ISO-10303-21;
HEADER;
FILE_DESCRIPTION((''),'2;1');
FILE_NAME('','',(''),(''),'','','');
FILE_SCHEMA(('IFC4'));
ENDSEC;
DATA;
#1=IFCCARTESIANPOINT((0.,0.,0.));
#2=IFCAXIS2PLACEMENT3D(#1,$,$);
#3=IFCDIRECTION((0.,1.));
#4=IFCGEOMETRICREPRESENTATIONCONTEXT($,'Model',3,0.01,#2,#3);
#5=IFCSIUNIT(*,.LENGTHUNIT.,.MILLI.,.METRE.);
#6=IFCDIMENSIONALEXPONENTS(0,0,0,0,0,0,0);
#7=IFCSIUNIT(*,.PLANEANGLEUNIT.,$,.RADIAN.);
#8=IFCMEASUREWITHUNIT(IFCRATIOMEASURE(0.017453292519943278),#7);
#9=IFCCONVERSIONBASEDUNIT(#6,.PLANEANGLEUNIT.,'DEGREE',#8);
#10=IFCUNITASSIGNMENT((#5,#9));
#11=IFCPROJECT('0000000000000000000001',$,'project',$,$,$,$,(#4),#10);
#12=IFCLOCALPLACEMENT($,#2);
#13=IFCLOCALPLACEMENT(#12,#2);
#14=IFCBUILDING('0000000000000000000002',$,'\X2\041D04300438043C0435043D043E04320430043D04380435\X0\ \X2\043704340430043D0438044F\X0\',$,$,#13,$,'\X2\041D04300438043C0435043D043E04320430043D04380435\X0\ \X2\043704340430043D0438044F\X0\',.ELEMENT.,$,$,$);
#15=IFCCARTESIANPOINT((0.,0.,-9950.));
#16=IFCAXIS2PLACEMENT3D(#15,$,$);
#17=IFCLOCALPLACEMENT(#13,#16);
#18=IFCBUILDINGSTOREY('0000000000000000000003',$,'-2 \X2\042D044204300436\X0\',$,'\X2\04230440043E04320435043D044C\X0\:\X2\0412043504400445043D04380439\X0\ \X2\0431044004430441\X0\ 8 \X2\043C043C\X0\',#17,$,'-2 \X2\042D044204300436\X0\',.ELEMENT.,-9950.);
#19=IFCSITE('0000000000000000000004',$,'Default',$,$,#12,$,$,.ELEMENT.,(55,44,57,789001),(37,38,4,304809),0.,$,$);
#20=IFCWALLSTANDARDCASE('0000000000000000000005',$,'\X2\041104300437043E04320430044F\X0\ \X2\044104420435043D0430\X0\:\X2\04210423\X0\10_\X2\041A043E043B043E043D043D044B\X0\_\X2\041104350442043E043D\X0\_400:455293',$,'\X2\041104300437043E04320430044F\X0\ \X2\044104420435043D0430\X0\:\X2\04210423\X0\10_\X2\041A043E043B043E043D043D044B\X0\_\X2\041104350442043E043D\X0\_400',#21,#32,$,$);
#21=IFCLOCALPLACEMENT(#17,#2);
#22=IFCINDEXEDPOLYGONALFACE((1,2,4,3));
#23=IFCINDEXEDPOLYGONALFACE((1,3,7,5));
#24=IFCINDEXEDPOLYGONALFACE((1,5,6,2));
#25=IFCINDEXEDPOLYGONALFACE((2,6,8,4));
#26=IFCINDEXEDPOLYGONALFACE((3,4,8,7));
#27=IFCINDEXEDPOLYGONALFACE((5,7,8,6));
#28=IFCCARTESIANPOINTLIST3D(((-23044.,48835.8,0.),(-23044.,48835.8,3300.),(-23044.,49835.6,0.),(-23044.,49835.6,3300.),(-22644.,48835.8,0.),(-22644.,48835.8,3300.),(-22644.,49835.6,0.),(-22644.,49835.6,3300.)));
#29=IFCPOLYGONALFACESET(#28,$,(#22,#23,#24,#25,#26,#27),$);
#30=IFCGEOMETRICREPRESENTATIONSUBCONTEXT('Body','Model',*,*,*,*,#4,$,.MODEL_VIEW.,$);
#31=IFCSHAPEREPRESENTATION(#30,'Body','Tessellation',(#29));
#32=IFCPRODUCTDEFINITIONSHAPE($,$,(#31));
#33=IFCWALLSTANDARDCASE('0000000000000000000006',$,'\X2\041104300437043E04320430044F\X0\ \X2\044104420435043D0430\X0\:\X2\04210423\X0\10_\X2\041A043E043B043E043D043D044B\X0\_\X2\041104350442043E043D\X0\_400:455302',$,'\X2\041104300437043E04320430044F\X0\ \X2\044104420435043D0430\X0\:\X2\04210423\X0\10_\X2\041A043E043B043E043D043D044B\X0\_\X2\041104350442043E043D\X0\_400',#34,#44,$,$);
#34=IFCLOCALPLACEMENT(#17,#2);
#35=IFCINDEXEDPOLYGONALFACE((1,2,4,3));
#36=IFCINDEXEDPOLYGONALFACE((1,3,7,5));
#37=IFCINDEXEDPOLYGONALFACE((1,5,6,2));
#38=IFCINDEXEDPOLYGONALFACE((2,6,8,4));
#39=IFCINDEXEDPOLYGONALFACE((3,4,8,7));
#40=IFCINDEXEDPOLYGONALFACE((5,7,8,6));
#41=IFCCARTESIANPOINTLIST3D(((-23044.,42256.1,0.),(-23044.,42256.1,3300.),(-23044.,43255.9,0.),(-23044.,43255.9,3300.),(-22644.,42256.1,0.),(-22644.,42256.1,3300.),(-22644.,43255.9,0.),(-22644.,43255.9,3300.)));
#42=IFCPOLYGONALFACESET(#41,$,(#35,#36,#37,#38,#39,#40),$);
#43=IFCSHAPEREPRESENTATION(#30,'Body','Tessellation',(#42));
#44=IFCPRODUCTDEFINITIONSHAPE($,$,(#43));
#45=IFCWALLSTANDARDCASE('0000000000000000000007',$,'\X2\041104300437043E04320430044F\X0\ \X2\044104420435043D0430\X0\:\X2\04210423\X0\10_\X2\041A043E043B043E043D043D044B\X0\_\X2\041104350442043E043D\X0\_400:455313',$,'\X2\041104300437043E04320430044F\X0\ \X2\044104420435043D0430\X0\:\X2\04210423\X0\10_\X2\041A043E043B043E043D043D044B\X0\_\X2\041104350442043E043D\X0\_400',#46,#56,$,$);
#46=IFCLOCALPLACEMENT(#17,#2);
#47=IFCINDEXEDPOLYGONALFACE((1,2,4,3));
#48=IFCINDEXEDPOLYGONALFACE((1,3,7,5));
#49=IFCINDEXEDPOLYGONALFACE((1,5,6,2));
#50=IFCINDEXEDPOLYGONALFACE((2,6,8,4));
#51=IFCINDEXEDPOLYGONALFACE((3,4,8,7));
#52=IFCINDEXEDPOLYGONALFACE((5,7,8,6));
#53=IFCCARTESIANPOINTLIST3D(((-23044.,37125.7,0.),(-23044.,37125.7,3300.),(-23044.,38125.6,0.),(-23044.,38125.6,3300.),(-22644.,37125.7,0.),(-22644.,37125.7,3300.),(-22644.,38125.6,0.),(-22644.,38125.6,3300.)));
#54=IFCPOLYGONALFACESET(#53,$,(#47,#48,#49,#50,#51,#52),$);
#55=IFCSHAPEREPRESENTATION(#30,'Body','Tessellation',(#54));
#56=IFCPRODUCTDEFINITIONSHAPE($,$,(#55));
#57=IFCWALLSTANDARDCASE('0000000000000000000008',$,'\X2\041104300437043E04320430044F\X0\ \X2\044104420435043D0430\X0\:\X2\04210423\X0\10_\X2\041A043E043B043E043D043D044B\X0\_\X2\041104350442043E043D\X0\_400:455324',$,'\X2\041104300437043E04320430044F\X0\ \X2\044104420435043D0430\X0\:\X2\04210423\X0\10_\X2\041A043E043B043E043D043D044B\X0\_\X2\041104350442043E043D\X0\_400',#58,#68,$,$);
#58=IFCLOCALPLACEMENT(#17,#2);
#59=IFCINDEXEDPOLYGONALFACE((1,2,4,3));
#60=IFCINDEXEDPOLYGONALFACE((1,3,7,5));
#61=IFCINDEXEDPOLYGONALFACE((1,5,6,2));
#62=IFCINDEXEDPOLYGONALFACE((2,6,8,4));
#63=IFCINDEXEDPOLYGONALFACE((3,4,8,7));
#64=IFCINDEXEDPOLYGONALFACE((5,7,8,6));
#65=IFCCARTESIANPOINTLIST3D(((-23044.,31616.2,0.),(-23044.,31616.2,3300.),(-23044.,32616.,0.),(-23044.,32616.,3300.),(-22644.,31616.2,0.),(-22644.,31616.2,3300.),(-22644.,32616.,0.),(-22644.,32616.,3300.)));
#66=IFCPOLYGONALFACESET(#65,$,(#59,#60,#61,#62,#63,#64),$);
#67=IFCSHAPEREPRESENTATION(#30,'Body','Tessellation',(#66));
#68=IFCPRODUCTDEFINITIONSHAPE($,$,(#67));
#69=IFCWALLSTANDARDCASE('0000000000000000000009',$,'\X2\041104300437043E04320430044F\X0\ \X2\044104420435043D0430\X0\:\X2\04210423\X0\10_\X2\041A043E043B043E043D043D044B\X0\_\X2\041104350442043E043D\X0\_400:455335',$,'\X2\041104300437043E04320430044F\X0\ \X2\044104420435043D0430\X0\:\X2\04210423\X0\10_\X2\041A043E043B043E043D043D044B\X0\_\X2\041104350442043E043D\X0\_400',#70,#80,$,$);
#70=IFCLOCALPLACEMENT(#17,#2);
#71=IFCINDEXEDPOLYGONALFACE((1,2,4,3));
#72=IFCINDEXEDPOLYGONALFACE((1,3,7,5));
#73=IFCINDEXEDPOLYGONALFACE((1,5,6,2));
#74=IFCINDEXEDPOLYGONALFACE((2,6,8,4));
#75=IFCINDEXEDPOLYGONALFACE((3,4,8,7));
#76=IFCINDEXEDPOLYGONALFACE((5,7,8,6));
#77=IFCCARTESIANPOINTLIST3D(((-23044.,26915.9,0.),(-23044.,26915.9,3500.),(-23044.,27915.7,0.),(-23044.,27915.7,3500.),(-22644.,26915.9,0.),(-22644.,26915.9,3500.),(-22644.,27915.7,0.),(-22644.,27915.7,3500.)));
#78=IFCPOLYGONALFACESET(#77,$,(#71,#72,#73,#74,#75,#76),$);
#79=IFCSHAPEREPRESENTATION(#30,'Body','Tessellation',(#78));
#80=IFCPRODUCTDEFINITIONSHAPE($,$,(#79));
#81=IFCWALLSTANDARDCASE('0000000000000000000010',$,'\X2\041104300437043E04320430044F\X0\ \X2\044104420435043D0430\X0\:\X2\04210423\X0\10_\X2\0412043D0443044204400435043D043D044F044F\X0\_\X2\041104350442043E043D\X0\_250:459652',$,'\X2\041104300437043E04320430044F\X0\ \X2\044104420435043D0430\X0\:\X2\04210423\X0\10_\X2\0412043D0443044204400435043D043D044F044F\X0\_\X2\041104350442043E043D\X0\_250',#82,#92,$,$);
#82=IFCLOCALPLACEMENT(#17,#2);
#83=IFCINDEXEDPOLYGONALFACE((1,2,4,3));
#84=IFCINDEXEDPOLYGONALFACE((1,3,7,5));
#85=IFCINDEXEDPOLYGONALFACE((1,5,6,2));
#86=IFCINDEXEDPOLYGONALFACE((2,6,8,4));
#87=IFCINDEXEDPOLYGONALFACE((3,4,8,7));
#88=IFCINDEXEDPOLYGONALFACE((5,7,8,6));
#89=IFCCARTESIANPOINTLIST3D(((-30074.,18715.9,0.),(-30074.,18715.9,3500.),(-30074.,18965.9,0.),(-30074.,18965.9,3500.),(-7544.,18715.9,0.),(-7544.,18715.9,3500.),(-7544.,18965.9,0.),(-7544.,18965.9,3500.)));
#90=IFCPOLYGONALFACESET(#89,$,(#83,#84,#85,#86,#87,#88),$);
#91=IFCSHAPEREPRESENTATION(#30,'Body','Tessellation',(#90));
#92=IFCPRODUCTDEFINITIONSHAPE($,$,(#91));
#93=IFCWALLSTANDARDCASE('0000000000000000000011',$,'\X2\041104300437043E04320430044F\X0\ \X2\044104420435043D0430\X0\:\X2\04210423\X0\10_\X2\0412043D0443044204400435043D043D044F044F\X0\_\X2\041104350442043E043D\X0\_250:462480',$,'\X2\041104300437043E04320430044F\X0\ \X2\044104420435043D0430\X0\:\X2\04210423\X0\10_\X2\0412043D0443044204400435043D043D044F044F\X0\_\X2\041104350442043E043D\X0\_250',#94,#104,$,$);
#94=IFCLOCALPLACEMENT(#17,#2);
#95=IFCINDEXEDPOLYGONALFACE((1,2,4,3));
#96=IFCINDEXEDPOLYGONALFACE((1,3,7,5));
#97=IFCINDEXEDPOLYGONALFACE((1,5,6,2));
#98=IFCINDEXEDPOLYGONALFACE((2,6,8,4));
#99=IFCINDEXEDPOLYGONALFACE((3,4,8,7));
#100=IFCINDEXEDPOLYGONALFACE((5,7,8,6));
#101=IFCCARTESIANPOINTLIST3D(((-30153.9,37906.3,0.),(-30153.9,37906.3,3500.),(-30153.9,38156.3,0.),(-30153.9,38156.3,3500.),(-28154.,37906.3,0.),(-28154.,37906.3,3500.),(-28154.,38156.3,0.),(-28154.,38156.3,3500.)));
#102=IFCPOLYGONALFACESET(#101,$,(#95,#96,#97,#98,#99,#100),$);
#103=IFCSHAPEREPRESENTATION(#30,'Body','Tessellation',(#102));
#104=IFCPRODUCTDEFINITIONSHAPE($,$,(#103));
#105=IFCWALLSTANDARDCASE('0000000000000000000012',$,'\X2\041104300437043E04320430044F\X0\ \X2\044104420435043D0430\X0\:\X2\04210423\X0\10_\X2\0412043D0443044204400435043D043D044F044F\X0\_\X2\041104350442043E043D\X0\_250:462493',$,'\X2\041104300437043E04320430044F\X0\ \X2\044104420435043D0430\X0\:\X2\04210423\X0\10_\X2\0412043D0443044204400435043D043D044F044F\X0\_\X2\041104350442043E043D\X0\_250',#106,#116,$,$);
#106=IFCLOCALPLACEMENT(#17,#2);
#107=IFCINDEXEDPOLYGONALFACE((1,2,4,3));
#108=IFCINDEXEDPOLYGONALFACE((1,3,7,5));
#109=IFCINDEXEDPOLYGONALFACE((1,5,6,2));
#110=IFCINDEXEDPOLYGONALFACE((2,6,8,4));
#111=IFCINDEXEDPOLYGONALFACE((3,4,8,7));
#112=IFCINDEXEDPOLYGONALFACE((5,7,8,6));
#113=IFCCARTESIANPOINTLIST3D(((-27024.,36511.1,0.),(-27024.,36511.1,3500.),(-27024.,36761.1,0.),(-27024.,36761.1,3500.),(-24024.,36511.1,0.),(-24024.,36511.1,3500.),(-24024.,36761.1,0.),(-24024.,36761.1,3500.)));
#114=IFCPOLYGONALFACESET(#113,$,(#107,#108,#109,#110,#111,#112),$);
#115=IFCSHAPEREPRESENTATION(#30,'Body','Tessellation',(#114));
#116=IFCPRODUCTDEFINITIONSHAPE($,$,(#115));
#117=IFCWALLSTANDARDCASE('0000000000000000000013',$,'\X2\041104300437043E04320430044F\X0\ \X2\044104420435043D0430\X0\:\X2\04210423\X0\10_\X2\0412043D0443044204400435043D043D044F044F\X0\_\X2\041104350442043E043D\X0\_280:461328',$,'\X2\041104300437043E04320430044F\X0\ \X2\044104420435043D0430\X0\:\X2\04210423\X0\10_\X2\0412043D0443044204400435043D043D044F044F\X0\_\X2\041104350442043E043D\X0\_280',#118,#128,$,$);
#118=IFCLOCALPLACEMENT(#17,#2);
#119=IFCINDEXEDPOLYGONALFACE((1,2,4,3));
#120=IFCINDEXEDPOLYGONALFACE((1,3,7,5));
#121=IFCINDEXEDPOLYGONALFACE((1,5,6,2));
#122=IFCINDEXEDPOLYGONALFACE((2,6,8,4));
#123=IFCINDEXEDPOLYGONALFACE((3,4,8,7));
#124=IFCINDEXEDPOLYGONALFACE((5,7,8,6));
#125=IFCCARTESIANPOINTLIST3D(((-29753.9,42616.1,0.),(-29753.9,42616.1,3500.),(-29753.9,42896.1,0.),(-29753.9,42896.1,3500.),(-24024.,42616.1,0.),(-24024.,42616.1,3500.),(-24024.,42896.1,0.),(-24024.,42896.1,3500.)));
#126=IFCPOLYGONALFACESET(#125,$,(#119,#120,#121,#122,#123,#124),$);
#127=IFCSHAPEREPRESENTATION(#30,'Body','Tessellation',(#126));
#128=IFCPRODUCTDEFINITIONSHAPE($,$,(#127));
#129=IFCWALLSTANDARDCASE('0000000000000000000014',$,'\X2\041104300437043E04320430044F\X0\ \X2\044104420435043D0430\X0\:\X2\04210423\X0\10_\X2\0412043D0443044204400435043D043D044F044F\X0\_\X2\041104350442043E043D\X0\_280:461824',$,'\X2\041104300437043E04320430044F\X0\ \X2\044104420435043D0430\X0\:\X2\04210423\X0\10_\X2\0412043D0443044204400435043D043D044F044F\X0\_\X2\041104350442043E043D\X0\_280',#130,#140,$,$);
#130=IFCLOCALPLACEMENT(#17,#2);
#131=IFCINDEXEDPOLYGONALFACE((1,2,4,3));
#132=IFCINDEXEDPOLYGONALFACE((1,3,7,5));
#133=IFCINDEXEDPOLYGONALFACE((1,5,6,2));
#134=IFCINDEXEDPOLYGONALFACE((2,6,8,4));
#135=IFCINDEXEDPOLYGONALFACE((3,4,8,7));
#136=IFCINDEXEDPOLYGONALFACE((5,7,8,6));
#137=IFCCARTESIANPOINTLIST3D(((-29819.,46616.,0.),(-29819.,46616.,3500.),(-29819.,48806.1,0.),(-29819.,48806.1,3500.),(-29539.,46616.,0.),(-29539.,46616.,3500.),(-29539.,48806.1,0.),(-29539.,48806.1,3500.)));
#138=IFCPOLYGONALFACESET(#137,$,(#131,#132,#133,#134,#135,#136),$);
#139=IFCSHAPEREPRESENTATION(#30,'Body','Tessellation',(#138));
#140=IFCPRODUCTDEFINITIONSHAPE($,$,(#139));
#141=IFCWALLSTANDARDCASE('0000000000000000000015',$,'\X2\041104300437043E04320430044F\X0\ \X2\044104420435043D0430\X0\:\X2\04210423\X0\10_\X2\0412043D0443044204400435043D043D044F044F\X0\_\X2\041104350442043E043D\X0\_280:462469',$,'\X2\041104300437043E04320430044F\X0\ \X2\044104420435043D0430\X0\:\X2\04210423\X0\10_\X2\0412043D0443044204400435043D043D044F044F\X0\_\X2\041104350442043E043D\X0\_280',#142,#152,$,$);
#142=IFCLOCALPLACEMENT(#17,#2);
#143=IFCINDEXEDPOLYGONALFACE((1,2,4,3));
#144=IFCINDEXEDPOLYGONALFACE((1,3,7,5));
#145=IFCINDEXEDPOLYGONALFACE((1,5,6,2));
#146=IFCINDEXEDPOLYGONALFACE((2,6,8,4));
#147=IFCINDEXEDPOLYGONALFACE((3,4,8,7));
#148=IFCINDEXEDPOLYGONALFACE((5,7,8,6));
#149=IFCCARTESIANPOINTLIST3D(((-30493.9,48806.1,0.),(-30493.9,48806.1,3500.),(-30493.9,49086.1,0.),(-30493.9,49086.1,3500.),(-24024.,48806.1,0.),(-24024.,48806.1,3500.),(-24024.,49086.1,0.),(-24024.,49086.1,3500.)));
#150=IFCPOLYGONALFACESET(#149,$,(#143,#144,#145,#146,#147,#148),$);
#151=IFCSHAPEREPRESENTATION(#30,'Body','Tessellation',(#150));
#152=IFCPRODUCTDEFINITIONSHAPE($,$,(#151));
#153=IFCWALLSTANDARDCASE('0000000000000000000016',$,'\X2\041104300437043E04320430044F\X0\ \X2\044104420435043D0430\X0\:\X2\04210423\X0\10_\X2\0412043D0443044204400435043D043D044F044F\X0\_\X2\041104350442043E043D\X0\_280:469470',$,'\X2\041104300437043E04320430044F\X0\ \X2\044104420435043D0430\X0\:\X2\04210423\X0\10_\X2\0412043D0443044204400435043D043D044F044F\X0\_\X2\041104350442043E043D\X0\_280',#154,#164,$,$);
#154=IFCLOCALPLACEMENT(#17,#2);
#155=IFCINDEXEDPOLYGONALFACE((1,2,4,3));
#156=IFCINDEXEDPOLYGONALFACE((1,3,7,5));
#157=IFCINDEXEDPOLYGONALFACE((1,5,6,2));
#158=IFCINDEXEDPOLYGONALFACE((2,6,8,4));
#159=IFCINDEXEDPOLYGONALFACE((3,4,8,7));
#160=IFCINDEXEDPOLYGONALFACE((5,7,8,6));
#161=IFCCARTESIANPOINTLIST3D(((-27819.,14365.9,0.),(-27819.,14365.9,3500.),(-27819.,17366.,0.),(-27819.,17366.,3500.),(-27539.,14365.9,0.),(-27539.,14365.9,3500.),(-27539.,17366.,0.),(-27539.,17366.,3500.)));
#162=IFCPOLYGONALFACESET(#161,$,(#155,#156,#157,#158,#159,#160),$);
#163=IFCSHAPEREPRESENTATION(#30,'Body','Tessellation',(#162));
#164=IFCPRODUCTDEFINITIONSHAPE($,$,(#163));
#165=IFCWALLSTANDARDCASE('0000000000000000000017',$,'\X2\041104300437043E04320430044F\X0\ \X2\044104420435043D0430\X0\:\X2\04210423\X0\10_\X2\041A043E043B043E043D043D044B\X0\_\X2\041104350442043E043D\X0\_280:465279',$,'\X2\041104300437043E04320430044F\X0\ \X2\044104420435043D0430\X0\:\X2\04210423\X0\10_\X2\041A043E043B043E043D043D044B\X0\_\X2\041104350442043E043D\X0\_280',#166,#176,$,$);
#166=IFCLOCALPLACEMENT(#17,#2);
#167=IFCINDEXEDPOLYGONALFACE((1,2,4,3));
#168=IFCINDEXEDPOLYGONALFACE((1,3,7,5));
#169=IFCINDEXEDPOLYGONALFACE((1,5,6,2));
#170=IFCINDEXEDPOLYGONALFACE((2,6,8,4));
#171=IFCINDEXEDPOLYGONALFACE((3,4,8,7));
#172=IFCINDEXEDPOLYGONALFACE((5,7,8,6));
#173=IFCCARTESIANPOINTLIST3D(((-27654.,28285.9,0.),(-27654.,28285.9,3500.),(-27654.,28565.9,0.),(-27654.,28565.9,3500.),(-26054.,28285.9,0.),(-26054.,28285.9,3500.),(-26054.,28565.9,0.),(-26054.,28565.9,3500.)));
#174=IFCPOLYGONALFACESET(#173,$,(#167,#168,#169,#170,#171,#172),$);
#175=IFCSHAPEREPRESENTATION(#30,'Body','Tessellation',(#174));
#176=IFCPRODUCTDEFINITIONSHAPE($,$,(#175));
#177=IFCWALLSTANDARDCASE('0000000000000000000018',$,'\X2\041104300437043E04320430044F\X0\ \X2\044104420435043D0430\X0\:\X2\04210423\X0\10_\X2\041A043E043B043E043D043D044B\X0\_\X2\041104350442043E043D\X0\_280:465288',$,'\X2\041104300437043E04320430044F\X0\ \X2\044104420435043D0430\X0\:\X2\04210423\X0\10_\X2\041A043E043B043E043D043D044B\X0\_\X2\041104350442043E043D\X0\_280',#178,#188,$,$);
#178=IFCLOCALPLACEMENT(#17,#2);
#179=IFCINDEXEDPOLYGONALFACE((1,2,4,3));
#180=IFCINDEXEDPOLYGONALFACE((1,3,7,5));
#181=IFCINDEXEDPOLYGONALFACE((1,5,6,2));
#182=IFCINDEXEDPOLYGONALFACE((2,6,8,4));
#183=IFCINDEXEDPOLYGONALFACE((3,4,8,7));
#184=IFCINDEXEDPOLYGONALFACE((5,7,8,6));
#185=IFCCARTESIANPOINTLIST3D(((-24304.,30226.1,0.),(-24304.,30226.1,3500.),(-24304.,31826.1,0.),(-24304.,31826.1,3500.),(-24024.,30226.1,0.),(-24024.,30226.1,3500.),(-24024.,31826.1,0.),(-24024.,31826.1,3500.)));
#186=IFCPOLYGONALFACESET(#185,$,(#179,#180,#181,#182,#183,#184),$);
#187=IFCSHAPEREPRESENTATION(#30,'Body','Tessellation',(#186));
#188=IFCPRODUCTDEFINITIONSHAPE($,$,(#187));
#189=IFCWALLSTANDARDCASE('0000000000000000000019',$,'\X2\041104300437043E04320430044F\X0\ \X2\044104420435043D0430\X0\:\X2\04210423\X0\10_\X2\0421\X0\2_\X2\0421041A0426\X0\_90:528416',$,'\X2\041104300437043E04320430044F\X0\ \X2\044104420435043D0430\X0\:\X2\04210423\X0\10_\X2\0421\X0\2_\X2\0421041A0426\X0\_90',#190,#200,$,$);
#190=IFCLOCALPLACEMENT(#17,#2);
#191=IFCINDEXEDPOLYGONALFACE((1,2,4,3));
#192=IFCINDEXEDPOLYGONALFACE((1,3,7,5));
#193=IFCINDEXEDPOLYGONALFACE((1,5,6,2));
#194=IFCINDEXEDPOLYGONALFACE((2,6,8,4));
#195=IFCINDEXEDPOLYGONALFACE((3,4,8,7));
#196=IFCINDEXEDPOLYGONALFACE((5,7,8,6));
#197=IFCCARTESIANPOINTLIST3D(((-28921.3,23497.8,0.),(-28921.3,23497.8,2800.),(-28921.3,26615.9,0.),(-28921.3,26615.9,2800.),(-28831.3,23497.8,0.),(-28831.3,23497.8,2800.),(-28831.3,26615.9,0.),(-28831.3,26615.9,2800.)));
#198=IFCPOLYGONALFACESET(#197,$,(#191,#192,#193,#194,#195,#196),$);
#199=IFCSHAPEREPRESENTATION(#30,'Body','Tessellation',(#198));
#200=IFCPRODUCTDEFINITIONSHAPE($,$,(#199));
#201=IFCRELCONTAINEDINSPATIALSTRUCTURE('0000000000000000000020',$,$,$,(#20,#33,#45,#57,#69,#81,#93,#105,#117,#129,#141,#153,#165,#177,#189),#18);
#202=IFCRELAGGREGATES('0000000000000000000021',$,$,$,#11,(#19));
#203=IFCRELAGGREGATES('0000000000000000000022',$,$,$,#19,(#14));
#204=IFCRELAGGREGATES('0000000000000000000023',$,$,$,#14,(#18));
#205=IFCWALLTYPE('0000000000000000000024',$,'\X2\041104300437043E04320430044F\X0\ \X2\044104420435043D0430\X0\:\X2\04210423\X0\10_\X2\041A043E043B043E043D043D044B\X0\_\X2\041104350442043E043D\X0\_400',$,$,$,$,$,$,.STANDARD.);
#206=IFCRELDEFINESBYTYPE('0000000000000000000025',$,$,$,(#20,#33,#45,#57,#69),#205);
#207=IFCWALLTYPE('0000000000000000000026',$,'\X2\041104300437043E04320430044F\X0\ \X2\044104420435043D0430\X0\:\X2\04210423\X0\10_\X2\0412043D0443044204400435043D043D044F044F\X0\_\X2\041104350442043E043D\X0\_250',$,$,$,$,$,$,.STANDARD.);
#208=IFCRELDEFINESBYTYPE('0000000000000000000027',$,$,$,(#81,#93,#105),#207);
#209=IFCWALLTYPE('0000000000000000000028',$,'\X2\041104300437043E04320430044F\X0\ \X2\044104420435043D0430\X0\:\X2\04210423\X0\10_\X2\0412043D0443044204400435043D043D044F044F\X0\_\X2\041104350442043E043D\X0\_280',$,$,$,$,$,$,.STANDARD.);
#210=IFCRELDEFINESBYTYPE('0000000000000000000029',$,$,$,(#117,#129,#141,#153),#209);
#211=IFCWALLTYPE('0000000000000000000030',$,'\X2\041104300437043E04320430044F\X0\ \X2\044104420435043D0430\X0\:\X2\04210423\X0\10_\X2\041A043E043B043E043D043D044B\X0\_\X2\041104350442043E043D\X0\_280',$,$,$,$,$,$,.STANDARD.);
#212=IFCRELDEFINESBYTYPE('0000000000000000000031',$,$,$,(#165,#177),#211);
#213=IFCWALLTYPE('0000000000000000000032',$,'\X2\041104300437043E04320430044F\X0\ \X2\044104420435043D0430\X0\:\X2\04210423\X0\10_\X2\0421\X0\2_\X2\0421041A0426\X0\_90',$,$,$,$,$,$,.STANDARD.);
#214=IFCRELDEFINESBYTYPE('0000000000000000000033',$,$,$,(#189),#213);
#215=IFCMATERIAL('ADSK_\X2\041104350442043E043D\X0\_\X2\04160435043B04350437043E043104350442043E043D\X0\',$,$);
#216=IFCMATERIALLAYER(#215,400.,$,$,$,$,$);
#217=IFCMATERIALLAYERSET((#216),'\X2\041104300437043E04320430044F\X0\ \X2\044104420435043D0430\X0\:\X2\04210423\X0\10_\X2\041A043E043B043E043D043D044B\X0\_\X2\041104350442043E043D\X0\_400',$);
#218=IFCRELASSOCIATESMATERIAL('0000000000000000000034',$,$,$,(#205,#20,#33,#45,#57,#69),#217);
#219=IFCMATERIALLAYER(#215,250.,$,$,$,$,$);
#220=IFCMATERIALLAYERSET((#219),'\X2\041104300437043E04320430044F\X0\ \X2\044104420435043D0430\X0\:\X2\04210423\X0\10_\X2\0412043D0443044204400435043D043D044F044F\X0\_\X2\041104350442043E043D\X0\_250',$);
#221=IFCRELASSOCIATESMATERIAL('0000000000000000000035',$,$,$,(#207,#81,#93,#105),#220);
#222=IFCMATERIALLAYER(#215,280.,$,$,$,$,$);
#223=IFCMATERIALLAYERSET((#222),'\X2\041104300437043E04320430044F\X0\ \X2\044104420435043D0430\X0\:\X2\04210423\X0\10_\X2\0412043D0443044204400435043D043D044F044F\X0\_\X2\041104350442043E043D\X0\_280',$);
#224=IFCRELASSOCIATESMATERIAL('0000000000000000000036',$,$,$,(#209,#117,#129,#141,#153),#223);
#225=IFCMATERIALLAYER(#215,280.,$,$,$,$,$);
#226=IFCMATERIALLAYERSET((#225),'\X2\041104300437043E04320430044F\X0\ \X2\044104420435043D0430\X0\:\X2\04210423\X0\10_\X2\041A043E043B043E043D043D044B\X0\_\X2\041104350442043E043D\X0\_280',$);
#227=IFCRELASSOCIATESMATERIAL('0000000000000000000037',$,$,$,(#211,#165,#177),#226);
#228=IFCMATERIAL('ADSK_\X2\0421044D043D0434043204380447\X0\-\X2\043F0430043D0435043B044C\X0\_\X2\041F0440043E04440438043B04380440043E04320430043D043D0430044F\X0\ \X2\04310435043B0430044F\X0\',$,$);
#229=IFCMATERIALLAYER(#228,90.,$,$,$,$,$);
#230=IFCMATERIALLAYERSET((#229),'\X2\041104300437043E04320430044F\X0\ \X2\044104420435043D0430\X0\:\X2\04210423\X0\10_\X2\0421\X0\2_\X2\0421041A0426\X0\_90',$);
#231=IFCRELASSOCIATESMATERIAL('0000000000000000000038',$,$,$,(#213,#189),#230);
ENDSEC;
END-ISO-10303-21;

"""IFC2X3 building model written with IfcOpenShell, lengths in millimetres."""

from ifc_helpers import new_model, entity, si_unit, converted_unit, direction, frame, frame_2d, origin, place, context, subcontext, project, spatial, rectangle, extrude, material, layer, layer_set, layer_usage, type_object, element, save


model = new_model("IFC2X3")

# Units and contexts
model_context = context("Model", 3, precision=0.01, world=origin(), true_north=direction((0.0, 1.0)))
body_context = subcontext(model_context, "Body", "Model", "MODEL_VIEW")
ifc_project = project(units=[si_unit("LENGTHUNIT", "METRE", prefix="MILLI"), converted_unit("PLANEANGLEUNIT", "DEGREE", entity("IfcRatioMeasure", 0.017453292519943278), si_unit("PLANEANGLEUNIT", "RADIAN"), dimensions=[0, 0, 0, 0, 0, 0, 0])], contexts=[model_context])

# Site, building, storey
site_placement = place(None, origin())
site = spatial("IfcSite", under=ifc_project, at=site_placement, Name="Default", CompositionType="ELEMENT", RefLatitude=(55, 44, 57, 789001), RefLongitude=(37, 38, 4, 304809), RefElevation=0.0)
building_placement = place(site_placement, origin())
building = spatial("IfcBuilding", under=site, at=building_placement, Name="Наименование здания", LongName="Наименование здания", CompositionType="ELEMENT")
storey_placement = place(building_placement, frame((0.0, 0.0, -9950.0)))
storey = spatial("IfcBuildingStorey", under=building, at=storey_placement, Name="-2 Этаж", ObjectType="Уровень:Верхний брус 8 мм", LongName="-2 Этаж", CompositionType="ELEMENT", Elevation=-9950.0)

# Walls
ifc_material_1 = material(Name="ADSK_Бетон_Железобетон")
ifc_layer_1 = layer(ifc_material_1, 400.0)
ifc_layer_set_1 = layer_set([ifc_layer_1], Name="Базовая стена:СУ10_Колонны_Бетон_400")
ifc_layer_usage_1 = layer_usage(ifc_layer_set_1, "AXIS2", "NEGATIVE", 200.0)
wall_type_1 = type_object("IfcWallType", Name="Базовая стена:СУ10_Колонны_Бетон_400", PredefinedType="STANDARD", material=ifc_layer_set_1)
for number, where, z_axis, x_axis, name in (
    (1, (-22844.0, 48835.8, 0.0), (0.0, 0.0, 1.0), (0.0, 1.0, 0.0), "Базовая стена:СУ10_Колонны_Бетон_400:455293"),
    (2, (-22844.0, 42256.1, 0.0), (0.0, 0.0, 1.0), (0.0, 1.0, 0.0), "Базовая стена:СУ10_Колонны_Бетон_400:455302"),
    (3, (-22844.0, 37125.7, 0.0), (0.0, 0.0, 1.0), (0.0, 1.0, 0.0), "Базовая стена:СУ10_Колонны_Бетон_400:455313"),
    (4, (-22844.0, 31616.2, 0.0), (0.0, 0.0, 1.0), (0.0, 1.0, 0.0), "Базовая стена:СУ10_Колонны_Бетон_400:455324"),
):
    element("IfcWallStandardCase", number, at=place(storey_placement, frame(where, z_axis=z_axis, x_axis=x_axis)), inside=storey, type_object=wall_type_1, material=ifc_layer_usage_1, Name=name, ObjectType="Базовая стена:СУ10_Колонны_Бетон_400", context=body_context, shape_type="SweptSolid", body=[
        extrude(rectangle(XDim=999.8, YDim=400.0, at=frame_2d((499.9, 0.0), x_axis=(-1.0, 0.0))), origin(), (0.0, 0.0, 1.0), 3300.0),
    ])
wall_1_placement = place(storey_placement, frame((-22844.0, 26915.9, 0.0), z_axis=(0.0, 0.0, 1.0), x_axis=(0.0, 1.0, 0.0)))
element("IfcWallStandardCase", 5, at=wall_1_placement, inside=storey, type_object=wall_type_1, material=ifc_layer_usage_1, Name="Базовая стена:СУ10_Колонны_Бетон_400:455335", ObjectType="Базовая стена:СУ10_Колонны_Бетон_400", context=body_context, shape_type="SweptSolid", body=[
    extrude(rectangle(XDim=999.8, YDim=400.0, at=frame_2d((499.9, 0.0), x_axis=(-1.0, 0.0))), origin(), (0.0, 0.0, 1.0), 3500.0),
])
ifc_layer_2 = layer(ifc_material_1, 250.0)
ifc_layer_set_2 = layer_set([ifc_layer_2], Name="Базовая стена:СУ10_Внутренняя_Бетон_250")
ifc_layer_usage_2 = layer_usage(ifc_layer_set_2, "AXIS2", "NEGATIVE", 125.0)
wall_type_2 = type_object("IfcWallType", Name="Базовая стена:СУ10_Внутренняя_Бетон_250", PredefinedType="STANDARD", material=ifc_layer_set_2)
wall_2_placement = place(storey_placement, frame((-30074.0, 18840.9, 0.0)))
element("IfcWallStandardCase", 6, at=wall_2_placement, inside=storey, type_object=wall_type_2, material=ifc_layer_usage_2, Name="Базовая стена:СУ10_Внутренняя_Бетон_250:459652", ObjectType="Базовая стена:СУ10_Внутренняя_Бетон_250", context=body_context, shape_type="SweptSolid", body=[
    extrude(rectangle(XDim=22530.1, YDim=250.0, at=frame_2d((11265.0, 0.0), x_axis=(-1.0, 0.0))), origin(), (0.0, 0.0, 1.0), 3500.0),
])
wall_3_placement = place(storey_placement, frame((-28154.0, 38031.3, 0.0), z_axis=(0.0, 0.0, 1.0), x_axis=(-1.0, 0.0, 0.0)))
element("IfcWallStandardCase", 7, at=wall_3_placement, inside=storey, type_object=wall_type_2, material=ifc_layer_usage_2, Name="Базовая стена:СУ10_Внутренняя_Бетон_250:462480", ObjectType="Базовая стена:СУ10_Внутренняя_Бетон_250", context=body_context, shape_type="SweptSolid", body=[
    extrude(rectangle(XDim=2000.0, YDim=250.0, at=frame_2d((1000.0, 0.0), x_axis=(-1.0, 0.0))), origin(), (0.0, 0.0, 1.0), 3500.0),
])
wall_4_placement = place(storey_placement, frame((-24024.0, 36636.1, 0.0), z_axis=(0.0, 0.0, 1.0), x_axis=(-1.0, 0.0, 0.0)))
element("IfcWallStandardCase", 8, at=wall_4_placement, inside=storey, type_object=wall_type_2, material=ifc_layer_usage_2, Name="Базовая стена:СУ10_Внутренняя_Бетон_250:462493", ObjectType="Базовая стена:СУ10_Внутренняя_Бетон_250", context=body_context, shape_type="SweptSolid", body=[
    extrude(rectangle(XDim=3000.1, YDim=250.0, at=frame_2d((1500.0, 0.0), x_axis=(-1.0, 0.0))), origin(), (0.0, 0.0, 1.0), 3500.0),
])
ifc_layer_3 = layer(ifc_material_1, 280.0)
ifc_layer_set_3 = layer_set([ifc_layer_3], Name="Базовая стена:СУ10_Внутренняя_Бетон_280")
ifc_layer_usage_3 = layer_usage(ifc_layer_set_3, "AXIS2", "NEGATIVE", 140.0)
wall_type_3 = type_object("IfcWallType", Name="Базовая стена:СУ10_Внутренняя_Бетон_280", PredefinedType="STANDARD", material=ifc_layer_set_3)
wall_5_placement = place(storey_placement, frame((-24024.0, 42756.1, 0.0), z_axis=(0.0, 0.0, 1.0), x_axis=(-1.0, 0.0, 0.0)))
element("IfcWallStandardCase", 9, at=wall_5_placement, inside=storey, type_object=wall_type_3, material=ifc_layer_usage_3, Name="Базовая стена:СУ10_Внутренняя_Бетон_280:461328", ObjectType="Базовая стена:СУ10_Внутренняя_Бетон_280", context=body_context, shape_type="SweptSolid", body=[
    extrude(rectangle(XDim=5730.0, YDim=280.0, at=frame_2d((2865.0, 0.0), x_axis=(-1.0, 0.0))), origin(), (0.0, 0.0, 1.0), 3500.0),
])
wall_6_placement = place(storey_placement, frame((-29679.0, 48806.1, 0.0), z_axis=(0.0, 0.0, 1.0), x_axis=(0.0, -1.0, 0.0)))
element("IfcWallStandardCase", 10, at=wall_6_placement, inside=storey, type_object=wall_type_3, material=ifc_layer_usage_3, Name="Базовая стена:СУ10_Внутренняя_Бетон_280:461824", ObjectType="Базовая стена:СУ10_Внутренняя_Бетон_280", context=body_context, shape_type="SweptSolid", body=[
    extrude(rectangle(XDim=2190.1, YDim=280.0, at=frame_2d((1095.1, 0.0), x_axis=(-1.0, 0.0))), origin(), (0.0, 0.0, 1.0), 3500.0),
])
wall_7_placement = place(storey_placement, frame((-24024.0, 48946.1, 0.0), z_axis=(0.0, 0.0, 1.0), x_axis=(-1.0, 0.0, 0.0)))
element("IfcWallStandardCase", 11, at=wall_7_placement, inside=storey, type_object=wall_type_3, material=ifc_layer_usage_3, Name="Базовая стена:СУ10_Внутренняя_Бетон_280:462469", ObjectType="Базовая стена:СУ10_Внутренняя_Бетон_280", context=body_context, shape_type="SweptSolid", body=[
    extrude(rectangle(XDim=6470.0, YDim=280.0, at=frame_2d((3235.0, 0.0), x_axis=(-1.0, 0.0))), origin(), (0.0, 0.0, 1.0), 3500.0),
])
wall_8_placement = place(storey_placement, frame((-27679.0, 17366.0, 0.0), z_axis=(0.0, 0.0, 1.0), x_axis=(0.0, -1.0, 0.0)))
element("IfcWallStandardCase", 12, at=wall_8_placement, inside=storey, type_object=wall_type_3, material=ifc_layer_usage_3, Name="Базовая стена:СУ10_Внутренняя_Бетон_280:469470", ObjectType="Базовая стена:СУ10_Внутренняя_Бетон_280", context=body_context, shape_type="SweptSolid", body=[
    extrude(rectangle(XDim=3000.0, YDim=280.0, at=frame_2d((1500.0, 0.0), x_axis=(-1.0, 0.0))), origin(), (0.0, 0.0, 1.0), 3500.0),
])
ifc_layer_4 = layer(ifc_material_1, 280.0)
ifc_layer_set_4 = layer_set([ifc_layer_4], Name="Базовая стена:СУ10_Колонны_Бетон_280")
ifc_layer_usage_4 = layer_usage(ifc_layer_set_4, "AXIS2", "NEGATIVE", 140.0)
wall_type_4 = type_object("IfcWallType", Name="Базовая стена:СУ10_Колонны_Бетон_280", PredefinedType="STANDARD", material=ifc_layer_set_4)
wall_9_placement = place(storey_placement, frame((-26054.0, 28425.9, 0.0), z_axis=(0.0, 0.0, 1.0), x_axis=(-1.0, 0.0, 0.0)))
element("IfcWallStandardCase", 13, at=wall_9_placement, inside=storey, type_object=wall_type_4, material=ifc_layer_usage_4, Name="Базовая стена:СУ10_Колонны_Бетон_280:465279", ObjectType="Базовая стена:СУ10_Колонны_Бетон_280", context=body_context, shape_type="SweptSolid", body=[
    extrude(rectangle(XDim=1600.0, YDim=280.0, at=frame_2d((800.0, 0.0), x_axis=(-1.0, 0.0))), origin(), (0.0, 0.0, 1.0), 3500.0),
])
wall_10_placement = place(storey_placement, frame((-24164.0, 31826.1, 0.0), z_axis=(0.0, 0.0, 1.0), x_axis=(0.0, -1.0, 0.0)))
element("IfcWallStandardCase", 14, at=wall_10_placement, inside=storey, type_object=wall_type_4, material=ifc_layer_usage_4, Name="Базовая стена:СУ10_Колонны_Бетон_280:465288", ObjectType="Базовая стена:СУ10_Колонны_Бетон_280", context=body_context, shape_type="SweptSolid", body=[
    extrude(rectangle(XDim=1600.1, YDim=280.0, at=frame_2d((800.0, 0.0), x_axis=(-1.0, 0.0))), origin(), (0.0, 0.0, 1.0), 3500.0),
])
ifc_material_2 = material(Name="ADSK_Сэндвич-панель_Профилированная белая")
ifc_layer_5 = layer(ifc_material_2, 90.0)
ifc_layer_set_5 = layer_set([ifc_layer_5], Name="Базовая стена:СУ10_С2_СКЦ_90")
ifc_layer_usage_5 = layer_usage(ifc_layer_set_5, "AXIS2", "NEGATIVE", 45.0)
wall_type_5 = type_object("IfcWallType", Name="Базовая стена:СУ10_С2_СКЦ_90", PredefinedType="STANDARD", material=ifc_layer_set_5)
wall_11_placement = place(storey_placement, frame((-28876.3, 26615.9, 0.0), z_axis=(0.0, 0.0, 1.0), x_axis=(0.0, -1.0, 0.0)))
element("IfcWallStandardCase", 15, at=wall_11_placement, inside=storey, type_object=wall_type_5, material=ifc_layer_usage_5, Name="Базовая стена:СУ10_С2_СКЦ_90:528416", ObjectType="Базовая стена:СУ10_С2_СКЦ_90", context=body_context, shape_type="SweptSolid", body=[
    extrude(rectangle(XDim=3118.1, YDim=90.0, at=frame_2d((1559.1, 0.0), x_axis=(-1.0, 0.0))), origin(), (0.0, 0.0, 1.0), 2800.0),
])

save(model, "model.ifc")
